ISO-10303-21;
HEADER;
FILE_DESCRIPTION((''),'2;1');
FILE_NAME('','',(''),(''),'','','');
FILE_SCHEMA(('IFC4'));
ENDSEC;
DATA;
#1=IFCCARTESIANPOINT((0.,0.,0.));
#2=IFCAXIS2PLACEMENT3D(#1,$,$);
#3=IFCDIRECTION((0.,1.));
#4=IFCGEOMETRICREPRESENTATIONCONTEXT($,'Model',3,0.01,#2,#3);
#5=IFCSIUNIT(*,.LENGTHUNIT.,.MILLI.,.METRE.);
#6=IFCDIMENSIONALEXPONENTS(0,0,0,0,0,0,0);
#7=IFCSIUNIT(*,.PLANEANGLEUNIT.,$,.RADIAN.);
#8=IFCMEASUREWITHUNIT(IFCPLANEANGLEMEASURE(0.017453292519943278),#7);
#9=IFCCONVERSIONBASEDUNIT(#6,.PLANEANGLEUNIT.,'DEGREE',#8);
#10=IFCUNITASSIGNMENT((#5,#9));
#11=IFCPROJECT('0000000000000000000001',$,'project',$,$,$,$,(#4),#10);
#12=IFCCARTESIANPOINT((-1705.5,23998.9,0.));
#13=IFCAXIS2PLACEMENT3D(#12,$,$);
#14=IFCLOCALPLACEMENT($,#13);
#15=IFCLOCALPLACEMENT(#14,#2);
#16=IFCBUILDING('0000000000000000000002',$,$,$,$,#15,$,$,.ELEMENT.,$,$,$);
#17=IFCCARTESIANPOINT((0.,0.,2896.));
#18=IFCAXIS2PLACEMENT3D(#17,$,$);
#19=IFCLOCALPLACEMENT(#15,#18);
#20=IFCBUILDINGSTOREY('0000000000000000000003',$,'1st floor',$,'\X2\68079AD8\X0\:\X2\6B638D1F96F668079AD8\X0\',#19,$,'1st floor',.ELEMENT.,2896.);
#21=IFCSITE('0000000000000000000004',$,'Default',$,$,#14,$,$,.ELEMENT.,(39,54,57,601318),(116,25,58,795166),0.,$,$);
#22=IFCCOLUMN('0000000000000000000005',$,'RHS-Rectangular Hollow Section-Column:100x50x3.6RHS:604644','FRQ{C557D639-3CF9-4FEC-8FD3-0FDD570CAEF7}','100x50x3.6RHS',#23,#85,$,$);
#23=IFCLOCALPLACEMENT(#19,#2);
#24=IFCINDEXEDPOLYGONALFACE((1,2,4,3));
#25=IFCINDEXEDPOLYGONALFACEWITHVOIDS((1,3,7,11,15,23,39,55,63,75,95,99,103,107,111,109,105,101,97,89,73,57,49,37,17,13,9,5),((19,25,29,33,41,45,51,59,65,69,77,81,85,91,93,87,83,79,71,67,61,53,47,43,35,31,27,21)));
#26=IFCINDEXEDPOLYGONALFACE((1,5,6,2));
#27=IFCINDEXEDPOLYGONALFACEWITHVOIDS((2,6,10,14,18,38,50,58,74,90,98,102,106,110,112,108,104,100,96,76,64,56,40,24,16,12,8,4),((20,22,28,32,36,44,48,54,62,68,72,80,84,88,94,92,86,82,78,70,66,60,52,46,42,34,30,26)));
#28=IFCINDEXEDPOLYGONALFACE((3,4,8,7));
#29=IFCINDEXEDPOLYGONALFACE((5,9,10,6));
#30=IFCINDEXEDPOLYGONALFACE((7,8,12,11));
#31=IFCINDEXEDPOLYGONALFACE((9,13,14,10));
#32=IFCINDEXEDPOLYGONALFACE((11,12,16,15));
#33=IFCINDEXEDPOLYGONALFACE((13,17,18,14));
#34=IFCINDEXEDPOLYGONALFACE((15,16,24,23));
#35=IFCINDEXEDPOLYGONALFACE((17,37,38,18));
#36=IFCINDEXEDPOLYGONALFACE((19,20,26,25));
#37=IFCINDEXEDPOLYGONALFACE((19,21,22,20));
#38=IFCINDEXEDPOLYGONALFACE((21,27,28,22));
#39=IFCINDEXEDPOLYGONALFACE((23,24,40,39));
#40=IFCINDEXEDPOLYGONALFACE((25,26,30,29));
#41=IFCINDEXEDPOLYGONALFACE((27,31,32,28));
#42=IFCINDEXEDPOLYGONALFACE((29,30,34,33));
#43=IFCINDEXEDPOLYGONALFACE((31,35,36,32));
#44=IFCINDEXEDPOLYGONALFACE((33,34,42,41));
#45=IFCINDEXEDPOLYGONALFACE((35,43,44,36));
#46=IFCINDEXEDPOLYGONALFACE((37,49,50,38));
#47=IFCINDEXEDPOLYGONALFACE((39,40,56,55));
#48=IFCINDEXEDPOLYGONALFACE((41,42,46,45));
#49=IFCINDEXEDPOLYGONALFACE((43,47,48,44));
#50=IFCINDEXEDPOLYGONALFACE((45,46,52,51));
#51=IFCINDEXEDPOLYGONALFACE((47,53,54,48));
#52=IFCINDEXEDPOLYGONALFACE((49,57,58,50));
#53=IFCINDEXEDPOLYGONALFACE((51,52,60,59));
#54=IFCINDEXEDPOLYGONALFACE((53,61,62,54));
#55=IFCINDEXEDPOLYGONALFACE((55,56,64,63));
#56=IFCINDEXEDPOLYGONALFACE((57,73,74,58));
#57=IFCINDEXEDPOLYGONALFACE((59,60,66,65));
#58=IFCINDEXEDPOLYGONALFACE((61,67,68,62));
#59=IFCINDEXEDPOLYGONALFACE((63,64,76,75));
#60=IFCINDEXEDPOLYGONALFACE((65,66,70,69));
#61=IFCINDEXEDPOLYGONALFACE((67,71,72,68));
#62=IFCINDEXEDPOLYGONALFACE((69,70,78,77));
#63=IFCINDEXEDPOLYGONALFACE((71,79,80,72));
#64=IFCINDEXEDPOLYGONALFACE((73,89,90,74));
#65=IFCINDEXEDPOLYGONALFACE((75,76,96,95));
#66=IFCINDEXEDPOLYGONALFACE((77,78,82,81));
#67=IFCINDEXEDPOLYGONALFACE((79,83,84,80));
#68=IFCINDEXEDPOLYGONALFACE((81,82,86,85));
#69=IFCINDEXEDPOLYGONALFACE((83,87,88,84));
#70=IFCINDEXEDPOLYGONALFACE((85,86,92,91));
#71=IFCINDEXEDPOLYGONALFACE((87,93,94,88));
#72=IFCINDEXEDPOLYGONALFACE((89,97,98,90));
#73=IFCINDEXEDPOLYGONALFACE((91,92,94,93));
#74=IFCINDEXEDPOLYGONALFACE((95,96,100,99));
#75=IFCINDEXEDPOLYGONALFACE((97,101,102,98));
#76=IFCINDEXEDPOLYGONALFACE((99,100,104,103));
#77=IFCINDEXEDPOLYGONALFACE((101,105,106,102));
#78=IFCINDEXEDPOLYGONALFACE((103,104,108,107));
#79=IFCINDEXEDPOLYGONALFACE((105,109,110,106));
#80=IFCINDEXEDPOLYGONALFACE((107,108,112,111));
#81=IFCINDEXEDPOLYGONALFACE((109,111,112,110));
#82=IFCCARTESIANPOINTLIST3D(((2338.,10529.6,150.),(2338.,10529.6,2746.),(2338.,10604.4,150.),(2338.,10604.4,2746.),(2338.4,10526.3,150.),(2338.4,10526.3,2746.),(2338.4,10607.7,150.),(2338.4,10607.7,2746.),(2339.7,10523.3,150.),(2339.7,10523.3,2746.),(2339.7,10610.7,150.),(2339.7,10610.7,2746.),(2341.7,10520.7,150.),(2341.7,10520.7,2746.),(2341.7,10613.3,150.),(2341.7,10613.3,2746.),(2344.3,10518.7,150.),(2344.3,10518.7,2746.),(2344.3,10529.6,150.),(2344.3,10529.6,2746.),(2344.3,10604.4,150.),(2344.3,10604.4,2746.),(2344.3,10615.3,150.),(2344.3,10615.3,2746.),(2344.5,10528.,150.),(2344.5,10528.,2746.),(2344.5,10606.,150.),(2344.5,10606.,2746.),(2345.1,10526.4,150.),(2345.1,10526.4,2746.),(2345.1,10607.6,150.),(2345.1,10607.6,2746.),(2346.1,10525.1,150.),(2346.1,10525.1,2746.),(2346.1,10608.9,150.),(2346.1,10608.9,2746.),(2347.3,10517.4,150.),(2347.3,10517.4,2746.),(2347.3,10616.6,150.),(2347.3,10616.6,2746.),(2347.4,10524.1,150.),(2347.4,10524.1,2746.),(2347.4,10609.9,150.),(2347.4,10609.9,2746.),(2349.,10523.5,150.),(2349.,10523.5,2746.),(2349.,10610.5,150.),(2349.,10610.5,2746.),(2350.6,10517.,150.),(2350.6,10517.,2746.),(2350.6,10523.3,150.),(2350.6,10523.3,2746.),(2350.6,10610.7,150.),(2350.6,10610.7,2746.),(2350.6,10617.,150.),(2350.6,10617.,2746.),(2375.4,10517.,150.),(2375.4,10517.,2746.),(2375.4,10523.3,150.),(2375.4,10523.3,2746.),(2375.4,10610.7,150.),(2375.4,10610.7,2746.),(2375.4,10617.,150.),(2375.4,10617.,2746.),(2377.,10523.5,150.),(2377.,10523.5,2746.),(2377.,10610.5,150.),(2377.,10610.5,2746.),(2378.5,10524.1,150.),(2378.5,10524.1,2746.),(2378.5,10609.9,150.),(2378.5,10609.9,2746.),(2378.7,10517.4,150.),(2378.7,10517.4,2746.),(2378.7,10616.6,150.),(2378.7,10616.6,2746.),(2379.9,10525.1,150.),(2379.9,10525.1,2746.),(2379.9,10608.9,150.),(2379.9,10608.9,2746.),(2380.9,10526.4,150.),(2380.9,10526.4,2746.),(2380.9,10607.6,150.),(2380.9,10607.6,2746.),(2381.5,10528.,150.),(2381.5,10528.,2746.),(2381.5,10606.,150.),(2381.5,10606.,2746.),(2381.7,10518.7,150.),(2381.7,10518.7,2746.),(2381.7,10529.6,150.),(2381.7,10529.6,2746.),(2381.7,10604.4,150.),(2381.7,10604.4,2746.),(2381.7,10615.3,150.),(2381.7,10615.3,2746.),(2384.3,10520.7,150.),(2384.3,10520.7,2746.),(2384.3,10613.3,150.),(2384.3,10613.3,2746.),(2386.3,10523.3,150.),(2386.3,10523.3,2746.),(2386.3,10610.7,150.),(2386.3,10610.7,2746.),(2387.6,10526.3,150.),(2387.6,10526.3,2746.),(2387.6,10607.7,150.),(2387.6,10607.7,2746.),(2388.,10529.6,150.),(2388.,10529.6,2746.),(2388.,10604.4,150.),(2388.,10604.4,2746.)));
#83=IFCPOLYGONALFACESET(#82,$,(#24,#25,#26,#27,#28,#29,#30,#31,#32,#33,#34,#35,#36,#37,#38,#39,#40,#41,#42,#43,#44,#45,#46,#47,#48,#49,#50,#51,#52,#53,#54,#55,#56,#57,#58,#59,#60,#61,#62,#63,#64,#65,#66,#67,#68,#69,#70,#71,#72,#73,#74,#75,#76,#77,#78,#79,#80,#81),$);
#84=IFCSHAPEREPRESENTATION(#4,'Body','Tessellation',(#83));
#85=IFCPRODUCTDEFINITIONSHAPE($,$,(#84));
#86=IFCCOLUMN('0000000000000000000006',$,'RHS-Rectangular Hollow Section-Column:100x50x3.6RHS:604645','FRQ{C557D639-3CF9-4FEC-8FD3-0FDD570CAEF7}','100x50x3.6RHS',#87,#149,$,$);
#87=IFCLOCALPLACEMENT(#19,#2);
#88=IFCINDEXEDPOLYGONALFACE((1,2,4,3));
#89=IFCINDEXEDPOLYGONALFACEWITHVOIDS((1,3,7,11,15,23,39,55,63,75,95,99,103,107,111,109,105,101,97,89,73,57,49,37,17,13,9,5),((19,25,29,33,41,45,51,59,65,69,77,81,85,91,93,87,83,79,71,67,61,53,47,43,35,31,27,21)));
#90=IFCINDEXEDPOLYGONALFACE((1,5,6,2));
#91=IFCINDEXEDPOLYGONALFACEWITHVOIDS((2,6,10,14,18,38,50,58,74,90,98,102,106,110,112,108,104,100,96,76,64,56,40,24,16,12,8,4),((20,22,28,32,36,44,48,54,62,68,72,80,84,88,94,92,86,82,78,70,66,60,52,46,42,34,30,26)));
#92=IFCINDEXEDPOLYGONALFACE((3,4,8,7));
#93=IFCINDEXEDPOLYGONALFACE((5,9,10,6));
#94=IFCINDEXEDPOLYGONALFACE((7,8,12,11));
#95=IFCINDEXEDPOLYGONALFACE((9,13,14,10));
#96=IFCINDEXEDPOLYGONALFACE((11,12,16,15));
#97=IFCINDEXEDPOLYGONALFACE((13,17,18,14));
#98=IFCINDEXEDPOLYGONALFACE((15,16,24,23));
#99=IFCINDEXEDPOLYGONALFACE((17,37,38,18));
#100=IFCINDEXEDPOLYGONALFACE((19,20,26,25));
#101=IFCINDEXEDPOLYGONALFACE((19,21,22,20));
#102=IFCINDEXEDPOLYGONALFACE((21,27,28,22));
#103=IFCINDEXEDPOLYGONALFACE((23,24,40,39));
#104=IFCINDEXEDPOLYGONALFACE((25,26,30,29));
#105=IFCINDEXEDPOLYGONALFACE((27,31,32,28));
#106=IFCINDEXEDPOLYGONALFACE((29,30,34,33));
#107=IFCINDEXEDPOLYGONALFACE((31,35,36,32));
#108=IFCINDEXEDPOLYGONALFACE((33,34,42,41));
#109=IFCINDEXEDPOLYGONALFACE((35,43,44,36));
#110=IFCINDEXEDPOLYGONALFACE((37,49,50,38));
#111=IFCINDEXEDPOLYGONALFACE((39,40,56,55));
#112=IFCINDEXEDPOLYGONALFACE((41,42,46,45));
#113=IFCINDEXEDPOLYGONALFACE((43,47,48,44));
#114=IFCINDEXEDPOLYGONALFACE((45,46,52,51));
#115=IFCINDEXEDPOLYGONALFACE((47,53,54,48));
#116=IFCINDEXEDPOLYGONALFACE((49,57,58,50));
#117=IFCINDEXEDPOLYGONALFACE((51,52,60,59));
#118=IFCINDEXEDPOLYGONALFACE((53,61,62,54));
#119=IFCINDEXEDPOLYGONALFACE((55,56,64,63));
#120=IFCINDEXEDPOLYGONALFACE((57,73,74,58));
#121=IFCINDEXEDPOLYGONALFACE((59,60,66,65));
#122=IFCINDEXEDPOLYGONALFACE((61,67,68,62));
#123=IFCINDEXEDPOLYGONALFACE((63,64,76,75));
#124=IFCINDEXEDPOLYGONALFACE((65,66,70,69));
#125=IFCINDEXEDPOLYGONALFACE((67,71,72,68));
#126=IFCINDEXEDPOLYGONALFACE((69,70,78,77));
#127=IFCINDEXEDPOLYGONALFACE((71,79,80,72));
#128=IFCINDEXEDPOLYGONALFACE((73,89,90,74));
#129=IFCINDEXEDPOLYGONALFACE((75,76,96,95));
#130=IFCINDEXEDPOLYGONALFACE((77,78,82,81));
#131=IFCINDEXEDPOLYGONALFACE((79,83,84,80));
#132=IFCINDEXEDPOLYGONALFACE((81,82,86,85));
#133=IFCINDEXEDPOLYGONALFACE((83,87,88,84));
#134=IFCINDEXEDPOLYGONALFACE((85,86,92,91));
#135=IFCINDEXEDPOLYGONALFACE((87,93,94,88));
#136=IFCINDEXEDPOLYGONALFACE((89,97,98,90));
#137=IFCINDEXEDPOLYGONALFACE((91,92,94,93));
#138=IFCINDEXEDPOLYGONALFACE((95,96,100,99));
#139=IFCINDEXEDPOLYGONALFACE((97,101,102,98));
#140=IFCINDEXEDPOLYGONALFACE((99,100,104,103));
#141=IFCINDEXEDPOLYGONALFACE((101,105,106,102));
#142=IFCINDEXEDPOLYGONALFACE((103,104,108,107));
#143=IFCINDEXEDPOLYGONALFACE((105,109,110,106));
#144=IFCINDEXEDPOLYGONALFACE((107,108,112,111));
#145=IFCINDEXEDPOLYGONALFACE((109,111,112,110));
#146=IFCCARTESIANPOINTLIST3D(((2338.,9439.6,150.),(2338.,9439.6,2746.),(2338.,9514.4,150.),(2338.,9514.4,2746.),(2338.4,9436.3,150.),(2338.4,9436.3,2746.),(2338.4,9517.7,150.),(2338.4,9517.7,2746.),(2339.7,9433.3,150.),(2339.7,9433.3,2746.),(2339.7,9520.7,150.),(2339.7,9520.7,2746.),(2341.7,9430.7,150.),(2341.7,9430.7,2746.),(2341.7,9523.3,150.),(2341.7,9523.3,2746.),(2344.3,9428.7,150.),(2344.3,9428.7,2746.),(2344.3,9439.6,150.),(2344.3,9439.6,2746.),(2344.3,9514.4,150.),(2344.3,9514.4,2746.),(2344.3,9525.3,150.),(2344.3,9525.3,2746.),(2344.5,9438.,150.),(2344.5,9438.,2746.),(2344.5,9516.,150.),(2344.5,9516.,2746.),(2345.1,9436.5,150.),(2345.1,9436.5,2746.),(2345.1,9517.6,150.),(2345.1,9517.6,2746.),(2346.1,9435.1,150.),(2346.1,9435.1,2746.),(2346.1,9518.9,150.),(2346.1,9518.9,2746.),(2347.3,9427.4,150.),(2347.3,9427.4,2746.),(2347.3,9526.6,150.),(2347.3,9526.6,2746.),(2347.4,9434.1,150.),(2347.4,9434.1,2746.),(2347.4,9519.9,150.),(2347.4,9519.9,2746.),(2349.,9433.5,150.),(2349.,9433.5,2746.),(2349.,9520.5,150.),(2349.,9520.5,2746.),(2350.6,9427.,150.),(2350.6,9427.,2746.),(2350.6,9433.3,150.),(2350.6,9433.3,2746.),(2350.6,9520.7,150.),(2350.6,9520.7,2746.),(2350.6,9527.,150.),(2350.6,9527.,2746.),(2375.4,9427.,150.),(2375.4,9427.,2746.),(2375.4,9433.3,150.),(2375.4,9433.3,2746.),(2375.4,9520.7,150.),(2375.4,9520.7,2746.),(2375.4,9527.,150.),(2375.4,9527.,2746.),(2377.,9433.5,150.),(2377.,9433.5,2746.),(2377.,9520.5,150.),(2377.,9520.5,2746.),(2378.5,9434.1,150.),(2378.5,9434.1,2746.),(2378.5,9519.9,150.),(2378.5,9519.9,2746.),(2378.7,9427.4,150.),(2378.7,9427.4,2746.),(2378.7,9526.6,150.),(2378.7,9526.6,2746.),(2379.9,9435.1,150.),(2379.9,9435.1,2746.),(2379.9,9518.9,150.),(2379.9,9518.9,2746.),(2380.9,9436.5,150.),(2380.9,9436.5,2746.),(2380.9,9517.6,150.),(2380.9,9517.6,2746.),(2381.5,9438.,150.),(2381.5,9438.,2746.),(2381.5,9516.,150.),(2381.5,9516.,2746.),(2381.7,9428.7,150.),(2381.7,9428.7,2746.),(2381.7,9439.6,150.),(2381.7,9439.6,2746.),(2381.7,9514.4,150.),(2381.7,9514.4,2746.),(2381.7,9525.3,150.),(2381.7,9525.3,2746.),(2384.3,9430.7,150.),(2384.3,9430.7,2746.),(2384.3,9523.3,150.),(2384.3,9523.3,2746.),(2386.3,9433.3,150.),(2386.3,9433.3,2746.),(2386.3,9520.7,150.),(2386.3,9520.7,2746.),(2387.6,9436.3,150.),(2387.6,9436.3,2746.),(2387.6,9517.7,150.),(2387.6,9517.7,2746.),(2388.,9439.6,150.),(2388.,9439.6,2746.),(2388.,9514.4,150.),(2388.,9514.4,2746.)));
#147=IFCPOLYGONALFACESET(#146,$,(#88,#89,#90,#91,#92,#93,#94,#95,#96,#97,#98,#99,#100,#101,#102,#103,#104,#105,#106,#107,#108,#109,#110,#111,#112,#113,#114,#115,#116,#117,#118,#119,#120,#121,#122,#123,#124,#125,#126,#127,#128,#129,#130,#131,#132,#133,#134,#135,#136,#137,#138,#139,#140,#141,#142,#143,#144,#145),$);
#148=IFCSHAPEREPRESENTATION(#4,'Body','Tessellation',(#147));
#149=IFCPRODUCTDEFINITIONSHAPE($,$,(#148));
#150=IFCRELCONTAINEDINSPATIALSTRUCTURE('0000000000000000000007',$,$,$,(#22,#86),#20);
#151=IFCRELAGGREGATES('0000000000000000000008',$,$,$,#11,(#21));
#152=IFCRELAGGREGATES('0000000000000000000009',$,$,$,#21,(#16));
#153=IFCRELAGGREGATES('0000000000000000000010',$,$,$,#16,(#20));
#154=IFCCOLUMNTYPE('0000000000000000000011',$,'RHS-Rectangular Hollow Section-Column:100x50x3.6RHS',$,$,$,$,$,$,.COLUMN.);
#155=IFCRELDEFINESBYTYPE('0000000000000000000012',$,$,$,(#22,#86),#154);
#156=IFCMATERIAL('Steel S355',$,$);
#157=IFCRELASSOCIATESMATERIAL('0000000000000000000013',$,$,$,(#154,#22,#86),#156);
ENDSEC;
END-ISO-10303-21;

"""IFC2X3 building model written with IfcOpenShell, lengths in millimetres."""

from ifc_helpers import new_model, entity, si_unit, converted_unit, direction, frame, origin, origin_2d, place, context, project, spatial, hollow_rectangle, extrude, clip, halfspace, material, type_object, element, save


model = new_model("IFC2X3")

# Units and contexts
model_context = context("Model", 3, precision=0.01, world=origin(), true_north=direction((0.0, 1.0)))
ifc_project = project(units=[si_unit("LENGTHUNIT", "METRE", prefix="MILLI"), converted_unit("PLANEANGLEUNIT", "DEGREE", entity("IfcPlaneAngleMeasure", 0.017453292519943278), si_unit("PLANEANGLEUNIT", "RADIAN"), dimensions=[0, 0, 0, 0, 0, 0, 0])], contexts=[model_context])

# Site, building, storey
site_placement = place(None, frame((-1705.5, 23998.9, 0.0)))
site = spatial("IfcSite", under=ifc_project, at=site_placement, Name="Default", CompositionType="ELEMENT", RefLatitude=(39, 54, 57, 601318), RefLongitude=(116, 25, 58, 795166), RefElevation=0.0)
building_placement = place(site_placement, origin())
building = spatial("IfcBuilding", under=site, at=building_placement, CompositionType="ELEMENT")
storey_placement = place(building_placement, frame((0.0, 0.0, 2896.0)))
storey = spatial("IfcBuildingStorey", under=building, at=storey_placement, Name="1st floor", ObjectType="标高:正负零标高", LongName="1st floor", CompositionType="ELEMENT", Elevation=2896.0)

# Columns
ifc_material_1 = material(Name="Steel S355")
column_type = type_object("IfcColumnType", Name="RHS-Rectangular Hollow Section-Column:100x50x3.6RHS", PredefinedType="COLUMN", material=ifc_material_1)
column_1_placement = place(storey_placement, frame((2363.0, 10567.0, 2746.0), z_axis=(0.0, 0.0, 1.0), x_axis=(-1.0, 0.0, 0.0)))
element("IfcColumn", 1, at=column_1_placement, inside=storey, type_object=column_type, material=ifc_material_1, Name="RHS-Rectangular Hollow Section-Column:100x50x3.6RHS:604644", Description="FRQ{C557D639-3CF9-4FEC-8FD3-0FDD570CAEF7}", ObjectType="100x50x3.6RHS", context=model_context, shape_type="Clipping", body=[
    clip(extrude(hollow_rectangle(XDim=50.0, YDim=100.0, WallThickness=6.3, InnerFilletRadius=6.3, OuterFilletRadius=12.6, at=origin_2d()), origin(), (0.0, 0.0, -1.0), 2651.9), halfspace(frame((2363.0, 10567.0, -2596.0), z_axis=(0.0, 0.0, 1.0), x_axis=(-1.0, 0.0, 0.0)), True)),
])
column_2_placement = place(storey_placement, frame((2363.0, 9477.0, 2746.0), z_axis=(0.0, 0.0, 1.0), x_axis=(-1.0, 0.0, 0.0)))
element("IfcColumn", 2, at=column_2_placement, inside=storey, type_object=column_type, material=ifc_material_1, Name="RHS-Rectangular Hollow Section-Column:100x50x3.6RHS:604645", Description="FRQ{C557D639-3CF9-4FEC-8FD3-0FDD570CAEF7}", ObjectType="100x50x3.6RHS", context=model_context, shape_type="Clipping", body=[
    clip(extrude(hollow_rectangle(XDim=50.0, YDim=100.0, WallThickness=6.3, InnerFilletRadius=6.3, OuterFilletRadius=12.6, at=origin_2d()), origin(), (0.0, 0.0, -1.0), 2651.9), halfspace(frame((2363.0, 9477.0, -2596.0), z_axis=(0.0, 0.0, 1.0), x_axis=(-1.0, 0.0, 0.0)), True)),
])

save(model, "model.ifc")
